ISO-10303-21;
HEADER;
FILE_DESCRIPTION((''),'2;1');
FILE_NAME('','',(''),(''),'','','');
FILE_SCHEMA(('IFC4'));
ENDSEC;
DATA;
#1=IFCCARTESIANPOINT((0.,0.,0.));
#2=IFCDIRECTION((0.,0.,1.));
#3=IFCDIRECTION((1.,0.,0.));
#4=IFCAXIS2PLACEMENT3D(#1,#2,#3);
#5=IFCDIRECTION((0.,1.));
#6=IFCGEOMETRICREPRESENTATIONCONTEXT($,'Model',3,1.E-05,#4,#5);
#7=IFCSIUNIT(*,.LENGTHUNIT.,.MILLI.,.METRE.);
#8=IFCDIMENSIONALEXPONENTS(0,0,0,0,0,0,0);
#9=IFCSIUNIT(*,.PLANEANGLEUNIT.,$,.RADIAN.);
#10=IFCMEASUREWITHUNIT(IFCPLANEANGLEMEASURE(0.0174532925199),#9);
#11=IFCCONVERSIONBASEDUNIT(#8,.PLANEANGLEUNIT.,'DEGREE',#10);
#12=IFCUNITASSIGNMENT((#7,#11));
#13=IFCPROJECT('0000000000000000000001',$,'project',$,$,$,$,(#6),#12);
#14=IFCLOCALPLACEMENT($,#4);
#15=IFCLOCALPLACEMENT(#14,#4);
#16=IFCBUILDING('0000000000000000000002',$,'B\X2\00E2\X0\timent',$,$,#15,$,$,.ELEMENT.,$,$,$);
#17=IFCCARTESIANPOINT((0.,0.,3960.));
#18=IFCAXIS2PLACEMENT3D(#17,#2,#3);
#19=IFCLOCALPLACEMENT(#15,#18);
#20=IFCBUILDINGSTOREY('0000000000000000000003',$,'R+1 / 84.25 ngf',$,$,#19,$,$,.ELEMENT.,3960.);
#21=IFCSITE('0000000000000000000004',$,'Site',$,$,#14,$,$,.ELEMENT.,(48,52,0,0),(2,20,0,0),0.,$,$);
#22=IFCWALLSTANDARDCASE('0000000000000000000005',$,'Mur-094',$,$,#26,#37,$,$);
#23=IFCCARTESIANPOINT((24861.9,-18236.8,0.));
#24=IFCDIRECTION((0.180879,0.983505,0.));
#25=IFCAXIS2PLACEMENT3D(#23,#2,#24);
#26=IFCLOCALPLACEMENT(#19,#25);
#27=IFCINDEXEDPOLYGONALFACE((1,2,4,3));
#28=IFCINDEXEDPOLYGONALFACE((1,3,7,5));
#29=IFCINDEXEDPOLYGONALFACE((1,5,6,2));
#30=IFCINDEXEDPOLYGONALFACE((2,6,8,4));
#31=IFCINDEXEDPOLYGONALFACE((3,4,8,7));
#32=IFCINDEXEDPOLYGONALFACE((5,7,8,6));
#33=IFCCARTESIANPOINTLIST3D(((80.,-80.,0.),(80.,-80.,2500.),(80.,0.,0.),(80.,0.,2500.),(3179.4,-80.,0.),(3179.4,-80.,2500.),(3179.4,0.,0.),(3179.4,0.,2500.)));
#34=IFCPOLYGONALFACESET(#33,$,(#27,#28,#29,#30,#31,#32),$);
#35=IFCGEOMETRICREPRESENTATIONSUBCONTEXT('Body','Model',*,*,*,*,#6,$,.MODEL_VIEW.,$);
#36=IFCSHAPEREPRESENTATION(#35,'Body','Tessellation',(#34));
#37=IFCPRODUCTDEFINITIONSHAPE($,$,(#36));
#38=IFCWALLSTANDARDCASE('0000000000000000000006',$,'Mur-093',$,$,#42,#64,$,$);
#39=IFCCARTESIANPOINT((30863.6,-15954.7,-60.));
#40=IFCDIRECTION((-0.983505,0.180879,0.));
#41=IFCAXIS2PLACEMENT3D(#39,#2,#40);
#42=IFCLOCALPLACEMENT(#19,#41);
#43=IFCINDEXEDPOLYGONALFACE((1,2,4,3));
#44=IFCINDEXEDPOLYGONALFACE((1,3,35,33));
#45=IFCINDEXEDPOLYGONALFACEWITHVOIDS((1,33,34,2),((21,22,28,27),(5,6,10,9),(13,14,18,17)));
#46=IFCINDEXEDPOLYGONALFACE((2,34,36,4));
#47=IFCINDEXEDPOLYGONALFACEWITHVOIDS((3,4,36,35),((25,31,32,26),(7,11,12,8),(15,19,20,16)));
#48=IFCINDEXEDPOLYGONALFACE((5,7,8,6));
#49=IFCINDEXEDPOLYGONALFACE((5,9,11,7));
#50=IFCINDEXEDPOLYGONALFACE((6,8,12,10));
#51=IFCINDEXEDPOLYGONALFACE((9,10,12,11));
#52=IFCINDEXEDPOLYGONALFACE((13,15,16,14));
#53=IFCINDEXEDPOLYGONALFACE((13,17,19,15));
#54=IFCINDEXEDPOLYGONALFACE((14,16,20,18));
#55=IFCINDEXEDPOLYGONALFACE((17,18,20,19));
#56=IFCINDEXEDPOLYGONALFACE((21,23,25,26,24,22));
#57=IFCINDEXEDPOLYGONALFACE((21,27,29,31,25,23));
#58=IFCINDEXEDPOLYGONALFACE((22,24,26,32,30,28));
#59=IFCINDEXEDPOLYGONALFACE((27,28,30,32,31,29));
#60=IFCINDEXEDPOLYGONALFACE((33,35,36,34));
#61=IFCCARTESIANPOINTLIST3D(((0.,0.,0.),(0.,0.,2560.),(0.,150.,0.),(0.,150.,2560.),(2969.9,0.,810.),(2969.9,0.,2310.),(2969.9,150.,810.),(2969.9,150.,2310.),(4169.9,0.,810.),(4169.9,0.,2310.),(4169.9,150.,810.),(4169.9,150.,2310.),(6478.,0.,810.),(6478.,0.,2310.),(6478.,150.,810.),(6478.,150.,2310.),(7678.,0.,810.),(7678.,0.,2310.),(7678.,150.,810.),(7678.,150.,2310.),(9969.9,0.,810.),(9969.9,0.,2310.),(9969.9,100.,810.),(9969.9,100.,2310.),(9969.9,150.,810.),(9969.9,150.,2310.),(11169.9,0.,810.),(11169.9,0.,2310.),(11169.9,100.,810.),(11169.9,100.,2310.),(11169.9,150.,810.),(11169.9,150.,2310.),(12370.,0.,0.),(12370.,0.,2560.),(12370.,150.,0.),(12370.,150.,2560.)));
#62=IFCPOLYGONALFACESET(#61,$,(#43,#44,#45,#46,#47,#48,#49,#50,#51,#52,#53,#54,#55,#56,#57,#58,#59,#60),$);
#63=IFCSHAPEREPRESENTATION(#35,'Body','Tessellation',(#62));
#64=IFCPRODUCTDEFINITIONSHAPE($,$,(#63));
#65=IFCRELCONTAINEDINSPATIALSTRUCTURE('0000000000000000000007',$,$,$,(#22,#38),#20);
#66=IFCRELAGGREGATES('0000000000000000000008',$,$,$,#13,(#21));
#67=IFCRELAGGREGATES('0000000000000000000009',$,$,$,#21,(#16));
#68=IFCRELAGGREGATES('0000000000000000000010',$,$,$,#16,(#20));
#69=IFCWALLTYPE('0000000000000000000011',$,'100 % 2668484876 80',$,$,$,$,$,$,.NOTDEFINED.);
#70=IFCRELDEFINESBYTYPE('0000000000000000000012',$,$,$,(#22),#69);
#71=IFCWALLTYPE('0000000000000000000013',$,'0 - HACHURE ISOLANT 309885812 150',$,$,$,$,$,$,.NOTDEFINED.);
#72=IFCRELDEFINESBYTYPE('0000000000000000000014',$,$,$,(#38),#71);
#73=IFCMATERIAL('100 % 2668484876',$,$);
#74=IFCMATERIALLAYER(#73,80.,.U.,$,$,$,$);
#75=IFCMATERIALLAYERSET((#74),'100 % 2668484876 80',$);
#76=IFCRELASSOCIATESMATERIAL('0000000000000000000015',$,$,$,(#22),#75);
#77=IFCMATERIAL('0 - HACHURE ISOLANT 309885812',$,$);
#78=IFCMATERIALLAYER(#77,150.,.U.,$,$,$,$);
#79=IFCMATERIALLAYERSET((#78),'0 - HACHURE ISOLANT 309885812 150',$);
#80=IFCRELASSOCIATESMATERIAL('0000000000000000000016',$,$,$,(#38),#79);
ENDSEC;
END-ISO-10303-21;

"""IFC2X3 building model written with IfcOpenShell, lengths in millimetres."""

from ifc_helpers import new_model, entity, si_unit, converted_unit, direction, frame, origin_with_axes, origin_2d_with_axis, place, context, subcontext, project, spatial, polyline, rectangle, outline, extrude, material, layer, layer_set, layer_usage, type_object, element, save


model = new_model("IFC2X3")

# Units and contexts
model_context = context("Model", 3, precision=1e-05, world=origin_with_axes(), true_north=direction((0.0, 1.0)))
body_context = subcontext(model_context, "Body", "Model", "MODEL_VIEW")
ifc_project = project(units=[si_unit("LENGTHUNIT", "METRE", prefix="MILLI"), converted_unit("PLANEANGLEUNIT", "DEGREE", entity("IfcPlaneAngleMeasure", 0.0174532925199), si_unit("PLANEANGLEUNIT", "RADIAN"), dimensions=[0, 0, 0, 0, 0, 0, 0])], contexts=[model_context])

# Site, building, storey
site_placement = place(None, origin_with_axes())
site = spatial("IfcSite", under=ifc_project, at=site_placement, Name="Site", CompositionType="ELEMENT", RefLatitude=(48, 52, 0, 0), RefLongitude=(2, 20, 0, 0), RefElevation=0.0)
building_placement = place(site_placement, origin_with_axes())
building = spatial("IfcBuilding", under=site, at=building_placement, Name="Bâtiment", CompositionType="ELEMENT")
storey_placement = place(building_placement, frame((0.0, 0.0, 3960.0), z_axis=(0.0, 0.0, 1.0), x_axis=(1.0, 0.0, 0.0)))
storey = spatial("IfcBuildingStorey", under=building, at=storey_placement, Name="R+1 / 84.25 ngf", CompositionType="ELEMENT", Elevation=3960.0)

# Wall
ifc_material_1 = material(Name="100 % 2668484876")
ifc_layer_1 = layer(ifc_material_1, 80.0, ventilated="UNKNOWN")
ifc_layer_set_1 = layer_set([ifc_layer_1], Name="100 % 2668484876 80")
wall_type_1 = type_object("IfcWallType", Name="100 % 2668484876 80", PredefinedType="NOTDEFINED")
ifc_layer_usage_1 = layer_usage(ifc_layer_set_1, "AXIS2", "POSITIVE", -80.0)
wall_1_placement = place(storey_placement, frame((24861.9, -18236.8, 0.0), z_axis=(0.0, 0.0, 1.0), x_axis=(0.180879, 0.983505, 0.0)))
element("IfcWallStandardCase", 1, at=wall_1_placement, inside=storey, type_object=wall_type_1, material=ifc_layer_usage_1, Name="Mur-094", context=body_context, shape_type="SweptSolid", body=[
    extrude(outline(polyline([(80.0, -80.0), (3179.4, -80.0), (3179.4, 0.0), (80.0, 0.0), (80.0, -80.0)])), origin_with_axes(), (0.0, 0.0, 1.0), 2500.0),
])

# Shared definitions
ifc_material_2 = material(Name="0 - HACHURE ISOLANT 309885812")
ifc_layer_2 = layer(ifc_material_2, 150.0, ventilated="UNKNOWN")
ifc_layer_set_2 = layer_set([ifc_layer_2], Name="0 - HACHURE ISOLANT 309885812 150")
wall_type_2 = type_object("IfcWallType", Name="0 - HACHURE ISOLANT 309885812 150", PredefinedType="NOTDEFINED")

# Wall, openings
ifc_layer_usage_2 = layer_usage(ifc_layer_set_2, "AXIS2", "NEGATIVE", 150.0)
wall_2_placement = place(storey_placement, frame((30863.6, -15954.7, -60.0), z_axis=(0.0, 0.0, 1.0), x_axis=(-0.983505, 0.180879, 0.0)))
wall_2 = element("IfcWallStandardCase", 2, at=wall_2_placement, inside=storey, type_object=wall_type_2, material=ifc_layer_usage_2, Name="Mur-093", context=body_context, shape_type="SweptSolid", body=[
    extrude(outline(polyline([(0.0, 0.0), (12370.0, 0.0), (12370.0, 150.0), (0.0, 150.0), (0.0, 0.0)])), origin_with_axes(), (0.0, 0.0, 1.0), 2560.0),
])
opening_1_placement = place(wall_2_placement, frame((3569.9, 0.0, 810.0), z_axis=(0.0, 0.0, 1.0), x_axis=(1.0, 0.0, 0.0)))
element("IfcOpeningElement", 3, at=opening_1_placement, cuts=wall_2, context=body_context, shape_type="SweptSolid", body=[
    extrude(rectangle(XDim=1200.0, YDim=1500.0, at=origin_2d_with_axis()), frame((0.0, -150.0, 750.0), z_axis=(0.0, 1.0, 0.0), x_axis=(1.0, 0.0, 0.0)), (0.0, 0.0, 1.0), 450.0),
])
opening_2_placement = place(wall_2_placement, frame((7078.0, 0.0, 810.0), z_axis=(0.0, 0.0, 1.0), x_axis=(1.0, 0.0, 0.0)))
element("IfcOpeningElement", 4, at=opening_2_placement, cuts=wall_2, context=body_context, shape_type="SweptSolid", body=[
    extrude(rectangle(XDim=1200.0, YDim=1500.0, at=origin_2d_with_axis()), frame((0.0, -150.0, 750.0), z_axis=(0.0, -1.0, 0.0), x_axis=(-1.0, 0.0, 0.0)), (0.0, 0.0, -1.0), 450.0),
])
opening_3_placement = place(wall_2_placement, frame((3569.9, 0.0, 810.0), z_axis=(0.0, 0.0, 1.0), x_axis=(1.0, 0.0, 0.0)))
element("IfcOpeningElement", 5, at=opening_3_placement, cuts=wall_2, context=body_context, shape_type="SweptSolid", body=[
    extrude(rectangle(XDim=1200.0, YDim=1500.0, at=origin_2d_with_axis()), frame((0.0, 300.0, 750.0), z_axis=(0.0, -1.0, 0.0), x_axis=(1.0, 0.0, 0.0)), (0.0, 0.0, 1.0), 450.0),
])
opening_4_placement = place(wall_2_placement, frame((10569.9, 0.0, 810.0), z_axis=(0.0, 0.0, 1.0), x_axis=(1.0, 0.0, 0.0)))
element("IfcOpeningElement", 6, at=opening_4_placement, cuts=wall_2, context=body_context, shape_type="SweptSolid", body=[
    extrude(rectangle(XDim=1200.0, YDim=1500.0, at=origin_2d_with_axis()), frame((0.0, -150.0, 750.0), z_axis=(0.0, 1.0, 0.0), x_axis=(1.0, 0.0, 0.0)), (0.0, 0.0, 1.0), 250.0),
    extrude(rectangle(XDim=1200.0, YDim=1500.0, at=origin_2d_with_axis()), frame((0.0, 300.0, 750.0), z_axis=(0.0, -1.0, 0.0), x_axis=(1.0, 0.0, 0.0)), (0.0, 0.0, 1.0), 200.0),
])
opening_5_placement = place(wall_2_placement, frame((7078.0, 0.0, 810.0), z_axis=(0.0, 0.0, 1.0), x_axis=(1.0, 0.0, 0.0)))
element("IfcOpeningElement", 7, at=opening_5_placement, cuts=wall_2, context=body_context, shape_type="SweptSolid", body=[
    extrude(rectangle(XDim=1200.0, YDim=1500.0, at=origin_2d_with_axis()), frame((0.0, 300.0, 750.0), z_axis=(0.0, -1.0, 0.0), x_axis=(1.0, 0.0, 0.0)), (0.0, 0.0, 1.0), 450.0),
])

save(model, "model.ifc")
